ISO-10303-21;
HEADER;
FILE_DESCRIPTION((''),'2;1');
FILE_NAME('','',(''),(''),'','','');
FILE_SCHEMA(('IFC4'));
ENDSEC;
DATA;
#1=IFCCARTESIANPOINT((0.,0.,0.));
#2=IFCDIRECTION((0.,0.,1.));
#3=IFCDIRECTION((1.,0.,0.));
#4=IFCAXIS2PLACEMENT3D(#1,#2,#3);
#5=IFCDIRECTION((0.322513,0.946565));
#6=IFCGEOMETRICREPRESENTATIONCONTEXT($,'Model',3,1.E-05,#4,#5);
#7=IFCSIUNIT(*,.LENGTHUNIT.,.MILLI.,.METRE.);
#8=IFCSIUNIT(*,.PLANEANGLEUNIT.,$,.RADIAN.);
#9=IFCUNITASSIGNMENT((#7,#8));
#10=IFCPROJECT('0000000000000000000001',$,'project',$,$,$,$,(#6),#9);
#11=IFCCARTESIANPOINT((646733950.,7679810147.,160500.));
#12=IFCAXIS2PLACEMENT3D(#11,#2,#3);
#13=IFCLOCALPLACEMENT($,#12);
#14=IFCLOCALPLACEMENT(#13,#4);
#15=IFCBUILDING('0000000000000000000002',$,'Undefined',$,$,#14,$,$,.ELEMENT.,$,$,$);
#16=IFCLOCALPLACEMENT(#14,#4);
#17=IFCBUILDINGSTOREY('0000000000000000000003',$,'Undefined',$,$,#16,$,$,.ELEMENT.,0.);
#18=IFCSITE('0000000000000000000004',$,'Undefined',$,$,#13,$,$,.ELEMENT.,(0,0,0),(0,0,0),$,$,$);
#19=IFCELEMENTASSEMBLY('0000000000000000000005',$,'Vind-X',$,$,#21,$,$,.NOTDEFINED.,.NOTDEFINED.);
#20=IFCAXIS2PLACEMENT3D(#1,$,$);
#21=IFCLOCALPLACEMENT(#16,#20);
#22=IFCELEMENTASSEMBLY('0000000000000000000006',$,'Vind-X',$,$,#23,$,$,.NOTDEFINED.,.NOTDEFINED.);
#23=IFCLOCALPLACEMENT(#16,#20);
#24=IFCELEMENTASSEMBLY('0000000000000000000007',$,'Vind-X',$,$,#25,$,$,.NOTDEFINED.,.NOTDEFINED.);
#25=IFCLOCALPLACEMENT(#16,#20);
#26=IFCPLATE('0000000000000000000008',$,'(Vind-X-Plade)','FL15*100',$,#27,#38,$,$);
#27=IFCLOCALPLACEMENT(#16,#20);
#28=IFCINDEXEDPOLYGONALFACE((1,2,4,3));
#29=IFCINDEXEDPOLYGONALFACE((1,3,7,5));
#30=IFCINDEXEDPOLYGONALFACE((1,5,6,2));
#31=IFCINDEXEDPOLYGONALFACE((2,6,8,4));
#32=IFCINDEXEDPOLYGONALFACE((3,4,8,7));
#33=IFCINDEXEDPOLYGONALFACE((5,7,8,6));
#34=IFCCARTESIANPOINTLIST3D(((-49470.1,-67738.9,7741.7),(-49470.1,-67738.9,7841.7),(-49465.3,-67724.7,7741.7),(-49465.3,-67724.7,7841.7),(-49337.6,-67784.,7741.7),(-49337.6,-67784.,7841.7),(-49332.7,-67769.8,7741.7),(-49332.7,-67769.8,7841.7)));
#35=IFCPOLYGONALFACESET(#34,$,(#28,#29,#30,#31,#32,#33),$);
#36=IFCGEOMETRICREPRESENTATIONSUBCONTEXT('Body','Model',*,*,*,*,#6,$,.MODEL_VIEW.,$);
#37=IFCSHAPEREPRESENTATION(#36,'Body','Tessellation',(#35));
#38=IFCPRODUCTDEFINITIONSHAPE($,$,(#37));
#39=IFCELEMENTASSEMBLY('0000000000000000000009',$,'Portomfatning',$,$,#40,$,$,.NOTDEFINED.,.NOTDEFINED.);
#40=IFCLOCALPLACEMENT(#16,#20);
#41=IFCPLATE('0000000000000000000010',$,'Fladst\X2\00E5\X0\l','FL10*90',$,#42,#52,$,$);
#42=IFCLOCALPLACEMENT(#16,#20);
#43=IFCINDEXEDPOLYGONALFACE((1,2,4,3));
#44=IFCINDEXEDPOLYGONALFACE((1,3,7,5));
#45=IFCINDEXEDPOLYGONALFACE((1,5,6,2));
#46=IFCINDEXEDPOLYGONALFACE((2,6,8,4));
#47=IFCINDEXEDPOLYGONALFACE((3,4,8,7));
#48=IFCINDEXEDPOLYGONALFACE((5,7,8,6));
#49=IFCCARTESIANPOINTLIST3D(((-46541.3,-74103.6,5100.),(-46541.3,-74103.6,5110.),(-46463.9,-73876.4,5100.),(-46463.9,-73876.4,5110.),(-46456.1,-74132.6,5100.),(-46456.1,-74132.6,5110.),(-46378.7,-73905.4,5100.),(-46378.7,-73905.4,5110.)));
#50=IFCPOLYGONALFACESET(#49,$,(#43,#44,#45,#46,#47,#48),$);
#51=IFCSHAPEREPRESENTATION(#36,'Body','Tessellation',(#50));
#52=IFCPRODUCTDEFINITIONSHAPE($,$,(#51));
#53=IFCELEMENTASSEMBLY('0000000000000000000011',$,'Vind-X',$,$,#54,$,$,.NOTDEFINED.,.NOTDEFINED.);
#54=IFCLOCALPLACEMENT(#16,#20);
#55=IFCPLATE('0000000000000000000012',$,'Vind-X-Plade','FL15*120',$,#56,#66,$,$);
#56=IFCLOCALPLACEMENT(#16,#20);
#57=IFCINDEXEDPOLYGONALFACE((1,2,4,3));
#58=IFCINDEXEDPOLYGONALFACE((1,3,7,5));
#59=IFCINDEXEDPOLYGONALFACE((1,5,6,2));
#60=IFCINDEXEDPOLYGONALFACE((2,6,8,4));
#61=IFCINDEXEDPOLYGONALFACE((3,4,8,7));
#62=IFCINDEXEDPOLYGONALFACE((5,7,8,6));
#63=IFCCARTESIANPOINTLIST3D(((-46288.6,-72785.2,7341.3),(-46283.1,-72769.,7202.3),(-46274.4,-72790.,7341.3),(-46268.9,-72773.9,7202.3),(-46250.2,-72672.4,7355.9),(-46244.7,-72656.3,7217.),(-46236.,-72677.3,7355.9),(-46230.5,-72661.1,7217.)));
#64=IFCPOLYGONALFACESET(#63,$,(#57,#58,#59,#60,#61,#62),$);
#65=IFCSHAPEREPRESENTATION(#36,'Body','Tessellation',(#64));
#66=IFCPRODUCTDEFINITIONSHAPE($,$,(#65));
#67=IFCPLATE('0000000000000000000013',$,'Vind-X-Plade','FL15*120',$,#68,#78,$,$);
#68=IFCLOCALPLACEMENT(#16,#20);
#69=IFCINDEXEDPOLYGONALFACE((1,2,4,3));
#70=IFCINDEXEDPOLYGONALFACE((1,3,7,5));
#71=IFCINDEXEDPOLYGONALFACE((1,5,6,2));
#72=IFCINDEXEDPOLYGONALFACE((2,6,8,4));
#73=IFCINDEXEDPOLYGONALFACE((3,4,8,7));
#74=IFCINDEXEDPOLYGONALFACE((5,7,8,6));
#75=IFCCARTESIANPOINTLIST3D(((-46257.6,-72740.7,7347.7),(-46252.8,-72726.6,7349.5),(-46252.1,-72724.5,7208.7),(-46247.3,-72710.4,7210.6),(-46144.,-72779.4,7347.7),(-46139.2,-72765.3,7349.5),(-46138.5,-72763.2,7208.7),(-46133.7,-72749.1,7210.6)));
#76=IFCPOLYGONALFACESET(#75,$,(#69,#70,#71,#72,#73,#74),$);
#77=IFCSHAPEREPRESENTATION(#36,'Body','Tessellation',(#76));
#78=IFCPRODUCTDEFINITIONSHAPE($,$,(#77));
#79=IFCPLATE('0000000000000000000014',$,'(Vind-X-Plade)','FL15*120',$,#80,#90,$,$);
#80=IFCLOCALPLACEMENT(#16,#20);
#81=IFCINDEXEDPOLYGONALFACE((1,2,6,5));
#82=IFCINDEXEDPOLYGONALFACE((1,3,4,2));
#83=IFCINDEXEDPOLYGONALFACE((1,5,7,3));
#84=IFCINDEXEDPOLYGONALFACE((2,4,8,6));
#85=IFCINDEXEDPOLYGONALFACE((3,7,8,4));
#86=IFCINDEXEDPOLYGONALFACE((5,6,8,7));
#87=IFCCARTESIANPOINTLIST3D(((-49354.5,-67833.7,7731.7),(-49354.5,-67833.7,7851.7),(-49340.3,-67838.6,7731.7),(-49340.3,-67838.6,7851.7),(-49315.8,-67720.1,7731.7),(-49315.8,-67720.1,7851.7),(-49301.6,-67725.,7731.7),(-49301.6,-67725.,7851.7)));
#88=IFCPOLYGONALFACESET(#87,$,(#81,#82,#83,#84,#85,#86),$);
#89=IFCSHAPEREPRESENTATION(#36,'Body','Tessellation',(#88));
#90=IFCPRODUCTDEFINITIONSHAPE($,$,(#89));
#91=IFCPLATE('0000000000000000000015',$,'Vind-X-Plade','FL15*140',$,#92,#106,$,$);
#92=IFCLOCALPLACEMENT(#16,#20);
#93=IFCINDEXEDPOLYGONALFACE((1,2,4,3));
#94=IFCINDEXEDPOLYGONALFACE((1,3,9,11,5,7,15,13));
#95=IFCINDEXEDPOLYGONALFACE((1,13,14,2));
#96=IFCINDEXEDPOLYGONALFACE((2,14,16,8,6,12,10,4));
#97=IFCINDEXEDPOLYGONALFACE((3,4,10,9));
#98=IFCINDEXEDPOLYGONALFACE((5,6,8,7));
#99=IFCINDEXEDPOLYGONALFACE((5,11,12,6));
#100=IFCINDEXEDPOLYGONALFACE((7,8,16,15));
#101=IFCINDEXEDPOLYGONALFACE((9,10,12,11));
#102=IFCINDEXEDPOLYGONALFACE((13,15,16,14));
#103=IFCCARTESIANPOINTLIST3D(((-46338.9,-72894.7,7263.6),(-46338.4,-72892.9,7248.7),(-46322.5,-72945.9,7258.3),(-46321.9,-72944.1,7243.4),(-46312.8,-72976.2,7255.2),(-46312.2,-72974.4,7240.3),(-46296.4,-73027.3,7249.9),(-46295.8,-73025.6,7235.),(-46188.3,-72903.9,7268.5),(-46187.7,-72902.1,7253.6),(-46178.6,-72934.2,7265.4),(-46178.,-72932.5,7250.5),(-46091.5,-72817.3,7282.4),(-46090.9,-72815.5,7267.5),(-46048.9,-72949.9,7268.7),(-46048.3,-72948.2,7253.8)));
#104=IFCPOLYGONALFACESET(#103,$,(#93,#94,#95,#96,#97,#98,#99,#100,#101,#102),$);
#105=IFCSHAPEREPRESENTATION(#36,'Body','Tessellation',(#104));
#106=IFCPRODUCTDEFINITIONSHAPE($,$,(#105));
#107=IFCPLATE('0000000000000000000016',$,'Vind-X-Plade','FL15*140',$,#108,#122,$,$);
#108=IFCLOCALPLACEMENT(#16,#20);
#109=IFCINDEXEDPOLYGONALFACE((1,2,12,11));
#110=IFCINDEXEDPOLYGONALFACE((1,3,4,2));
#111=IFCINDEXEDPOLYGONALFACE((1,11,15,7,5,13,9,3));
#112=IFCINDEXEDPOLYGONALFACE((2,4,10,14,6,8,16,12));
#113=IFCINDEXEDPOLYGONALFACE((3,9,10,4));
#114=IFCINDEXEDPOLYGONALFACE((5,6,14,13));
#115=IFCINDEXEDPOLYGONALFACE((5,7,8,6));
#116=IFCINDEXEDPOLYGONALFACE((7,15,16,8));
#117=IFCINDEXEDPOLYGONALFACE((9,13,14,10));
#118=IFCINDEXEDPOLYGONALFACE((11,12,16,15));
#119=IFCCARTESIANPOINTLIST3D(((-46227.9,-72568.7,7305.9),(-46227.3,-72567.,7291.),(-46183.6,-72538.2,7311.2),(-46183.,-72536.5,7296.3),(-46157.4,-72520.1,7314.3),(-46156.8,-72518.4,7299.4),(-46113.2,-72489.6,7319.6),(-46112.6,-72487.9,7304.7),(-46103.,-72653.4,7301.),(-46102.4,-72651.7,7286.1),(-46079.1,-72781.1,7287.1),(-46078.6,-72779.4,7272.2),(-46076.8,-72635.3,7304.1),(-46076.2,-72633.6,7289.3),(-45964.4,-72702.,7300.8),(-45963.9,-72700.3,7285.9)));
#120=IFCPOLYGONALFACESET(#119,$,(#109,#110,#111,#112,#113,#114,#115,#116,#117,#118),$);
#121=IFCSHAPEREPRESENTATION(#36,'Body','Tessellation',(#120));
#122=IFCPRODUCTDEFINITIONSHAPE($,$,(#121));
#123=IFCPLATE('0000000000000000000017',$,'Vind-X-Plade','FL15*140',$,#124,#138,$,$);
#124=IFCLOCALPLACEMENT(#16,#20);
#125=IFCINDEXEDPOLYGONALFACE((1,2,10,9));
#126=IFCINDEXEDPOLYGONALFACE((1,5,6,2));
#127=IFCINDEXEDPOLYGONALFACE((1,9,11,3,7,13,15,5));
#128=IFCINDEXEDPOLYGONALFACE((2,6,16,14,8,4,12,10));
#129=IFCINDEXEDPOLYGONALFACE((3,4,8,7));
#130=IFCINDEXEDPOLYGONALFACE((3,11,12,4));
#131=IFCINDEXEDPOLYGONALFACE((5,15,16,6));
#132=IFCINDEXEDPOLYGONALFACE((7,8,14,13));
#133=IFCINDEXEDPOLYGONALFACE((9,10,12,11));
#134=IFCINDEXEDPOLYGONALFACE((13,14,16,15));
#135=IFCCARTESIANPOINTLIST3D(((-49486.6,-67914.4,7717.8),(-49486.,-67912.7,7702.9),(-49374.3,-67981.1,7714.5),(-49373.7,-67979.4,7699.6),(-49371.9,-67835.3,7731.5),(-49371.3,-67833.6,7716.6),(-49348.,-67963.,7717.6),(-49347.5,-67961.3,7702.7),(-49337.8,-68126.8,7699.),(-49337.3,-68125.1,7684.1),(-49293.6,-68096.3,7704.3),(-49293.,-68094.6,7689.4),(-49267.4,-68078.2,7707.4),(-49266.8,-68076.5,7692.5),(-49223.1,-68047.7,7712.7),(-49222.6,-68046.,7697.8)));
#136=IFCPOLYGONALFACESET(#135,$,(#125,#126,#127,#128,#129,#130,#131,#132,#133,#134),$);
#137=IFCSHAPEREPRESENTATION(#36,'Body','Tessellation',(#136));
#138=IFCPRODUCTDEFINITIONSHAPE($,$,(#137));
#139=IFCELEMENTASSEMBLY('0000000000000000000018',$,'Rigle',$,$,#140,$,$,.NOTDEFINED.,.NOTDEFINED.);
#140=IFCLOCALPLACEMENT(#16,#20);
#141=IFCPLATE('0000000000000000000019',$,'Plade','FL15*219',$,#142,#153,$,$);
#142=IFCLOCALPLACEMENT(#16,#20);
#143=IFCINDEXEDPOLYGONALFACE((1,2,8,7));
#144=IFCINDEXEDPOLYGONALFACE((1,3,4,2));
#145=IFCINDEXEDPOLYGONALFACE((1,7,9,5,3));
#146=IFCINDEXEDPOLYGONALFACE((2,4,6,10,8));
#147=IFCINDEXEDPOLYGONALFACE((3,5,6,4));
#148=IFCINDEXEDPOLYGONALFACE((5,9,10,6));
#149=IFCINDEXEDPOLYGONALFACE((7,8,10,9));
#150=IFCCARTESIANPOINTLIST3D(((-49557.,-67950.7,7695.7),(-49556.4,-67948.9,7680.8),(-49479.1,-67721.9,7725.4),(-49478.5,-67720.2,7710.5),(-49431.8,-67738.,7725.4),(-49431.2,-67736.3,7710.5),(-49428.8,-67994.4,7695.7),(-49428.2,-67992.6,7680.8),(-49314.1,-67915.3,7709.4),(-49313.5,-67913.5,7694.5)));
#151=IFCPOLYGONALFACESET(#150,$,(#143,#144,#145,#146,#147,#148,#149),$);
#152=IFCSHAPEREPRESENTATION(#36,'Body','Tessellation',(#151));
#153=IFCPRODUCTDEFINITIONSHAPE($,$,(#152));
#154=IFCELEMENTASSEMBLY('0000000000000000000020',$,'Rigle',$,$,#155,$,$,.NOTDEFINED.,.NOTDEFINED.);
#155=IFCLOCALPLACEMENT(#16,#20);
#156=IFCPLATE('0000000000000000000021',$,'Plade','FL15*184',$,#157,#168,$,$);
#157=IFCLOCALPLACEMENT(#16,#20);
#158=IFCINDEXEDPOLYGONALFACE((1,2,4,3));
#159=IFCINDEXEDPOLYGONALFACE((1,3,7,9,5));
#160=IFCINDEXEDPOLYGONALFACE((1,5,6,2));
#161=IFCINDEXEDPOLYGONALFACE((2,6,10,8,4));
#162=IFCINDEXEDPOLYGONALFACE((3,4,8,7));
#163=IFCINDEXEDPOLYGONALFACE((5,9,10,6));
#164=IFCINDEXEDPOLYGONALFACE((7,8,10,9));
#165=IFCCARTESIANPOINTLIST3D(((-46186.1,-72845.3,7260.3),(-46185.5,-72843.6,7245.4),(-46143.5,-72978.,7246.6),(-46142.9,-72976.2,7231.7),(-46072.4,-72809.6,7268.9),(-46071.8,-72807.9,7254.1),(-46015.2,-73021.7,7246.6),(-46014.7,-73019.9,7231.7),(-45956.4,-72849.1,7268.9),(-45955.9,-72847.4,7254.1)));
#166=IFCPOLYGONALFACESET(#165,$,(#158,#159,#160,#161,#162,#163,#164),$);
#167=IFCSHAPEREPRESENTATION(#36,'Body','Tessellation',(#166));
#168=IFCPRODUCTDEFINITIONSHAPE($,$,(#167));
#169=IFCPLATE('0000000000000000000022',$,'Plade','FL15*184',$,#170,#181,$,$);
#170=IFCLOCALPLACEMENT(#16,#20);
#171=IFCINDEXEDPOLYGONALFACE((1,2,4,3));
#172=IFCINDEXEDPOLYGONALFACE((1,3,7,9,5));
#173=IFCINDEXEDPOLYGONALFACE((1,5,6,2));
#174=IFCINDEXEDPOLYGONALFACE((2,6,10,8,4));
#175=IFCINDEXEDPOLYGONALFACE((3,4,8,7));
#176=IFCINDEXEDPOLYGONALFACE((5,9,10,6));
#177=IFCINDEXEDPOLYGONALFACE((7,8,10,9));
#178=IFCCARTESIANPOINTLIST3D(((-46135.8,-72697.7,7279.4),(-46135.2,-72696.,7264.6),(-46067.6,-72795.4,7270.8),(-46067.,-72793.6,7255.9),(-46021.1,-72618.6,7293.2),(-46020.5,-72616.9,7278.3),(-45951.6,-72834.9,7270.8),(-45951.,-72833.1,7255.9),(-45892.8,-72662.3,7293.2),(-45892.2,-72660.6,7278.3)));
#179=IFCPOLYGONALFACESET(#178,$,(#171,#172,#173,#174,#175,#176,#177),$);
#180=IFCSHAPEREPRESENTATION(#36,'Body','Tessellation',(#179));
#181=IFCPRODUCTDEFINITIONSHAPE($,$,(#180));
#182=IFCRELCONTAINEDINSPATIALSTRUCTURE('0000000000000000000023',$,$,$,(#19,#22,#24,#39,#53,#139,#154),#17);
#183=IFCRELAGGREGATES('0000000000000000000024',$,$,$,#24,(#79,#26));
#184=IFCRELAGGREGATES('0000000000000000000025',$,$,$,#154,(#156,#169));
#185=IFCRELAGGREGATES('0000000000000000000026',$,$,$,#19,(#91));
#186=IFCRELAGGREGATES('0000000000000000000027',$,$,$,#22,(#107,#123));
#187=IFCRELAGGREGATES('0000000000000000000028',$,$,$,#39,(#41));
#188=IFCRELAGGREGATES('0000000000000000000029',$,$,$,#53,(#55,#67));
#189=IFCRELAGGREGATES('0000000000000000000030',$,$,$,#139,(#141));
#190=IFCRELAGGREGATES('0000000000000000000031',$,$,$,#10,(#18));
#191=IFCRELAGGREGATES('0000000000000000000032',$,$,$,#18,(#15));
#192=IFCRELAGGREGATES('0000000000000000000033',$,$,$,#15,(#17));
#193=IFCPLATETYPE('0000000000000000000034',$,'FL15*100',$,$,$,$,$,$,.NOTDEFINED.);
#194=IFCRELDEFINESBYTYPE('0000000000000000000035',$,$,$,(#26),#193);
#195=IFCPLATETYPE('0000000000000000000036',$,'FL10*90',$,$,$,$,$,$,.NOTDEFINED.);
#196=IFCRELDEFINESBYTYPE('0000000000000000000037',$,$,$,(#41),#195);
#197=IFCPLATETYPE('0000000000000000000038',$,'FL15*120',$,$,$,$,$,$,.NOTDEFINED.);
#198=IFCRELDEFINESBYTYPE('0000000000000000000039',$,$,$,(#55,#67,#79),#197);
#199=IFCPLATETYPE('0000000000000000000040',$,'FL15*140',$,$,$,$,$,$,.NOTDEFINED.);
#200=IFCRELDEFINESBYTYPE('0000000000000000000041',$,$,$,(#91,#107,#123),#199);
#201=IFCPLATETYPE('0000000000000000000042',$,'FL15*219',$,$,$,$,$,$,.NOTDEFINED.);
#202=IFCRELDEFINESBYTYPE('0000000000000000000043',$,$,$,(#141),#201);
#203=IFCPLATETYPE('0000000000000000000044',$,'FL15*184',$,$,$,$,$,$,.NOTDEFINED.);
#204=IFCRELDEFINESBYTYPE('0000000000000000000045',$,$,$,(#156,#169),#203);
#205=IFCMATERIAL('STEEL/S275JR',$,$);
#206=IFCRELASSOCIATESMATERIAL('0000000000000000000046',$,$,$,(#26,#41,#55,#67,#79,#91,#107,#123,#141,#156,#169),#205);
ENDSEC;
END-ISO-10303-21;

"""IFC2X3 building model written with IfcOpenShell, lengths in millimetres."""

from ifc_helpers import new_model, si_unit, direction, frame, origin_with_axes, place, context, subcontext, project, spatial, polyline, outline, extrude, material, type_object, element, aggregate, save


model = new_model("IFC2X3")

# Units and contexts
model_context = context("Model", 3, precision=1e-05, world=origin_with_axes(), true_north=direction((0.322513, 0.946565)))
body_context = subcontext(model_context, "Body", "Model", "MODEL_VIEW")
ifc_project = project(units=[si_unit("LENGTHUNIT", "METRE", prefix="MILLI"), si_unit("PLANEANGLEUNIT", "RADIAN")], contexts=[model_context])

# Site, building, storey
site_placement = place(None, frame((646733950.0, 7679810147.0, 160500.0), z_axis=(0.0, 0.0, 1.0), x_axis=(1.0, 0.0, 0.0)))
site = spatial("IfcSite", under=ifc_project, at=site_placement, Name="Undefined", CompositionType="ELEMENT", RefLatitude=(0, 0, 0), RefLongitude=(0, 0, 0))
building_placement = place(site_placement, origin_with_axes())
building = spatial("IfcBuilding", under=site, at=building_placement, Name="Undefined", CompositionType="ELEMENT")
storey_placement = place(building_placement, origin_with_axes())
storey = spatial("IfcBuildingStorey", under=building, at=storey_placement, Name="Undefined", CompositionType="ELEMENT", Elevation=0.0)

# Element assemblies
assembly_1_placement = place(storey_placement, origin_with_axes())
assembly_1 = element("IfcElementAssembly", 1, at=assembly_1_placement, inside=storey, Name="Vind-X", AssemblyPlace="NOTDEFINED", PredefinedType="NOTDEFINED")
assembly_2_placement = place(storey_placement, origin_with_axes())
assembly_2 = element("IfcElementAssembly", 2, at=assembly_2_placement, inside=storey, Name="Vind-X", AssemblyPlace="NOTDEFINED", PredefinedType="NOTDEFINED")

# Element assemblies, plates
assembly_3_placement = place(storey_placement, origin_with_axes())
assembly_3 = element("IfcElementAssembly", 3, at=assembly_3_placement, inside=storey, Name="Vind-X", AssemblyPlace="NOTDEFINED", PredefinedType="NOTDEFINED")
ifc_material_1 = material(Name="STEEL/S275JR")
plate_type_1 = type_object("IfcPlateType", Name="FL15*100", PredefinedType="NOTDEFINED")
plate_1_placement = place(assembly_3_placement, frame((-49467.7, -67731.8, 7741.7), z_axis=(0.322513, 0.946565, 0.0), x_axis=(0.0, 0.0, 1.0)))
plate_1 = element("IfcPlate", 4, at=plate_1_placement, type_object=plate_type_1, material=ifc_material_1, Name="(Vind-X-Plade)", Description="FL15*100", context=body_context, shape_type="SweptSolid", body=[
    extrude(outline(polyline([(0.0, 0.0), (100.0, 0.0), (100.0, 140.0), (0.0, 140.0), (0.0, 0.0)])), frame((0.0, 0.0, -7.5), z_axis=(0.0, 0.0, 1.0), x_axis=(1.0, 0.0, 0.0)), (0.0, 0.0, 1.0), 15.0),
])
assembly_4_placement = place(storey_placement, origin_with_axes())
assembly_4 = element("IfcElementAssembly", 5, at=assembly_4_placement, inside=storey, Name="Portomfatning", AssemblyPlace="NOTDEFINED", PredefinedType="NOTDEFINED")
plate_type_2 = type_object("IfcPlateType", Name="FL10*90", PredefinedType="NOTDEFINED")
plate_2_placement = place(assembly_4_placement, frame((-46421.3, -73890.9, 5105.0), z_axis=(0.0, 0.0, 1.0), x_axis=(-0.322513, -0.946565, 0.0)))
plate_2 = element("IfcPlate", 6, at=plate_2_placement, type_object=plate_type_2, material=ifc_material_1, Name="Fladstål", Description="FL10*90", context=body_context, shape_type="SweptSolid", body=[
    extrude(outline(polyline([(0.0, -45.0), (0.0, 45.0), (240.0, 45.0), (240.0, -45.0), (0.0, -45.0)])), frame((0.0, 0.0, -5.0), z_axis=(0.0, 0.0, 1.0), x_axis=(1.0, 0.0, 0.0)), (0.0, 0.0, 1.0), 10.0),
])

# Element assembly, plates
assembly_5_placement = place(storey_placement, origin_with_axes())
assembly_5 = element("IfcElementAssembly", 7, at=assembly_5_placement, inside=storey, Name="Vind-X", AssemblyPlace="NOTDEFINED", PredefinedType="NOTDEFINED")
plate_type_3 = type_object("IfcPlateType", Name="FL15*120", PredefinedType="NOTDEFINED")
plate_3_placement = place(assembly_5_placement, frame((-46237.6, -72658.7, 7217.0), z_axis=(0.946565, -0.322513, 0.0), x_axis=(-0.039304, -0.115357, 0.992546)))
plate_3 = element("IfcPlate", 8, at=plate_3_placement, type_object=plate_type_3, material=ifc_material_1, Name="Vind-X-Plade", Description="FL15*120", context=body_context, shape_type="SweptSolid", body=[
    extrude(outline(polyline([(0.0, 0.0), (140.0, 0.0), (140.0, 120.0), (0.0, 120.0), (0.0, 0.0)])), frame((0.0, 0.0, -7.5), z_axis=(0.0, 0.0, 1.0), x_axis=(1.0, 0.0, 0.0)), (0.0, 0.0, 1.0), 15.0),
])
plate_4_placement = place(assembly_5_placement, frame((-46138.8, -72764.3, 7279.1), z_axis=(0.320109, 0.93951, 0.121869), x_axis=(-0.946565, 0.322513, 0.0)))
plate_4 = element("IfcPlate", 9, at=plate_4_placement, type_object=plate_type_3, material=ifc_material_1, Name="Vind-X-Plade", Description="FL15*120", context=body_context, shape_type="SweptSolid", body=[
    extrude(outline(polyline([(0.0, -70.0), (0.0, 70.0), (120.0, 70.0), (120.0, -70.0), (0.0, -70.0)])), frame((0.0, 0.0, -7.5), z_axis=(0.0, 0.0, 1.0), x_axis=(1.0, 0.0, 0.0)), (0.0, 0.0, 1.0), 15.0),
])

# Plates
plate_5_placement = place(assembly_3_placement, frame((-49347.4, -67836.1, 7851.7), z_axis=(-0.946565, 0.322513, 0.0), x_axis=(0.322513, 0.946565, 0.0)))
plate_5 = element("IfcPlate", 10, at=plate_5_placement, type_object=plate_type_3, material=ifc_material_1, Name="(Vind-X-Plade)", Description="FL15*120", context=body_context, shape_type="SweptSolid", body=[
    extrude(outline(polyline([(0.0, 0.0), (120.0, 0.0), (120.0, 120.0), (0.0, 120.0), (0.0, 0.0)])), frame((0.0, 0.0, -7.5), z_axis=(0.0, 0.0, 1.0), x_axis=(1.0, 0.0, 0.0)), (0.0, 0.0, 1.0), 15.0),
])
aggregate(assembly_3, [plate_5, plate_1])
plate_type_4 = type_object("IfcPlateType", Name="FL15*140", PredefinedType="NOTDEFINED")
plate_6_placement = place(assembly_1_placement, frame((-46296.1, -73026.5, 7242.4), z_axis=(-0.039304, -0.115357, 0.992546), x_axis=(0.951886, 0.297799, 0.072306)))
plate_6 = element("IfcPlate", 11, at=plate_6_placement, type_object=plate_type_4, material=ifc_material_1, Name="Vind-X-Plade", Description="FL15*140", context=body_context, shape_type="SweptSolid", body=[
    extrude(outline(polyline([(0.0, 0.0), (260.0, 0.0), (260.0, 140.0), (0.0, 140.0), (0.0, 86.0), (141.0, 86.0), (141.0, 54.0), (0.0, 54.0), (0.0, 0.0)])), frame((0.0, 0.0, -7.5), z_axis=(0.0, 0.0, 1.0), x_axis=(1.0, 0.0, 0.0)), (0.0, 0.0, 1.0), 15.0),
])
plate_7_placement = place(assembly_2_placement, frame((-46227.6, -72567.8, 7298.5), z_axis=(-0.039304, -0.115357, 0.992546), x_axis=(0.57204, -0.817032, -0.072306)))
plate_7 = element("IfcPlate", 12, at=plate_7_placement, type_object=plate_type_4, material=ifc_material_1, Name="Vind-X-Plade", Description="FL15*140", context=body_context, shape_type="SweptSolid", body=[
    extrude(outline(polyline([(0.0, 0.0), (260.0, 0.0), (260.0, 140.0), (0.0, 140.0), (0.0, 86.0), (141.0, 86.0), (141.0, 54.0), (0.0, 54.0), (0.0, 0.0)])), frame((0.0, 0.0, -7.5), z_axis=(0.0, 0.0, 1.0), x_axis=(1.0, 0.0, 0.0)), (0.0, 0.0, 1.0), 15.0),
])
plate_8_placement = place(assembly_2_placement, frame((-49222.8, -68046.9, 7705.3), z_axis=(-0.039304, -0.115357, 0.992546), x_axis=(-0.57204, 0.817032, 0.072306)))
plate_8 = element("IfcPlate", 13, at=plate_8_placement, type_object=plate_type_4, material=ifc_material_1, Name="Vind-X-Plade", Description="FL15*140", context=body_context, shape_type="SweptSolid", body=[
    extrude(outline(polyline([(0.0, 0.0), (260.0, 0.0), (260.0, 140.0), (0.0, 140.0), (0.0, 86.0), (141.0, 86.0), (141.0, 54.0), (0.0, 54.0), (0.0, 0.0)])), frame((0.0, 0.0, -7.5), z_axis=(0.0, 0.0, 1.0), x_axis=(1.0, 0.0, 0.0)), (0.0, 0.0, 1.0), 15.0),
])

# Element assembly, plate
assembly_6_placement = place(storey_placement, origin_with_axes())
assembly_6 = element("IfcElementAssembly", 14, at=assembly_6_placement, inside=storey, Name="Rigle", AssemblyPlace="NOTDEFINED", PredefinedType="NOTDEFINED")
plate_type_5 = type_object("IfcPlateType", Name="FL15*219", PredefinedType="NOTDEFINED")
plate_9_placement = place(assembly_6_placement, frame((-49478.8, -67721.0, 7717.9), z_axis=(-0.039304, -0.115357, 0.992546), x_axis=(-0.320109, -0.93951, -0.121869)))
plate_9 = element("IfcPlate", 15, at=plate_9_placement, type_object=plate_type_5, material=ifc_material_1, Name="Plade", Description="FL15*219", context=body_context, shape_type="SweptSolid", body=[
    extrude(outline(polyline([(0.0, 0.0), (243.5, 0.0), (243.5, 135.5), (130.8, 218.6), (0.0, 50.0), (0.0, 0.0)])), frame((0.0, 0.0, -7.5), z_axis=(0.0, 0.0, 1.0), x_axis=(1.0, 0.0, 0.0)), (0.0, 0.0, 1.0), 15.0),
])

# Element assembly, plates
assembly_7_placement = place(storey_placement, origin_with_axes())
assembly_7 = element("IfcElementAssembly", 16, at=assembly_7_placement, inside=storey, Name="Rigle", AssemblyPlace="NOTDEFINED", PredefinedType="NOTDEFINED")
plate_type_6 = type_object("IfcPlateType", Name="FL15*184", PredefinedType="NOTDEFINED")
plate_10_placement = place(assembly_7_placement, frame((-46015.0, -73020.8, 7239.1), z_axis=(-0.039304, -0.115357, 0.992546), x_axis=(0.320109, 0.93951, 0.121869)))
plate_10 = element("IfcPlate", 17, at=plate_10_placement, type_object=plate_type_6, material=ifc_material_1, Name="Plade", Description="FL15*184", context=body_context, shape_type="SweptSolid", body=[
    extrude(outline(polyline([(0.0, 0.0), (183.7, 0.0), (183.7, 122.5), (112.7, 218.6), (0.0, 135.5), (0.0, 0.0)])), frame((0.0, 0.0, -7.5), z_axis=(0.0, 0.0, 1.0), x_axis=(1.0, 0.0, 0.0)), (0.0, 0.0, 1.0), 15.0),
])
plate_11_placement = place(assembly_7_placement, frame((-45951.3, -72834.0, 7263.3), z_axis=(-0.039304, -0.115357, 0.992546), x_axis=(0.320109, 0.93951, 0.121869)))
plate_11 = element("IfcPlate", 18, at=plate_11_placement, type_object=plate_type_6, material=ifc_material_1, Name="Plade", Description="FL15*184", context=body_context, shape_type="SweptSolid", body=[
    extrude(outline(polyline([(0.0, 0.0), (183.7, 0.0), (183.7, 135.5), (71.0, 218.6), (0.0, 122.5), (0.0, 0.0)])), frame((0.0, 0.0, -7.5), z_axis=(0.0, 0.0, 1.0), x_axis=(1.0, 0.0, 0.0)), (0.0, 0.0, 1.0), 15.0),
])
aggregate(assembly_7, [plate_10, plate_11])

aggregate(assembly_1, [plate_6])
aggregate(assembly_2, [plate_7, plate_8])
aggregate(assembly_4, [plate_2])
aggregate(assembly_5, [plate_3, plate_4])
aggregate(assembly_6, [plate_9])

save(model, "model.ifc")
